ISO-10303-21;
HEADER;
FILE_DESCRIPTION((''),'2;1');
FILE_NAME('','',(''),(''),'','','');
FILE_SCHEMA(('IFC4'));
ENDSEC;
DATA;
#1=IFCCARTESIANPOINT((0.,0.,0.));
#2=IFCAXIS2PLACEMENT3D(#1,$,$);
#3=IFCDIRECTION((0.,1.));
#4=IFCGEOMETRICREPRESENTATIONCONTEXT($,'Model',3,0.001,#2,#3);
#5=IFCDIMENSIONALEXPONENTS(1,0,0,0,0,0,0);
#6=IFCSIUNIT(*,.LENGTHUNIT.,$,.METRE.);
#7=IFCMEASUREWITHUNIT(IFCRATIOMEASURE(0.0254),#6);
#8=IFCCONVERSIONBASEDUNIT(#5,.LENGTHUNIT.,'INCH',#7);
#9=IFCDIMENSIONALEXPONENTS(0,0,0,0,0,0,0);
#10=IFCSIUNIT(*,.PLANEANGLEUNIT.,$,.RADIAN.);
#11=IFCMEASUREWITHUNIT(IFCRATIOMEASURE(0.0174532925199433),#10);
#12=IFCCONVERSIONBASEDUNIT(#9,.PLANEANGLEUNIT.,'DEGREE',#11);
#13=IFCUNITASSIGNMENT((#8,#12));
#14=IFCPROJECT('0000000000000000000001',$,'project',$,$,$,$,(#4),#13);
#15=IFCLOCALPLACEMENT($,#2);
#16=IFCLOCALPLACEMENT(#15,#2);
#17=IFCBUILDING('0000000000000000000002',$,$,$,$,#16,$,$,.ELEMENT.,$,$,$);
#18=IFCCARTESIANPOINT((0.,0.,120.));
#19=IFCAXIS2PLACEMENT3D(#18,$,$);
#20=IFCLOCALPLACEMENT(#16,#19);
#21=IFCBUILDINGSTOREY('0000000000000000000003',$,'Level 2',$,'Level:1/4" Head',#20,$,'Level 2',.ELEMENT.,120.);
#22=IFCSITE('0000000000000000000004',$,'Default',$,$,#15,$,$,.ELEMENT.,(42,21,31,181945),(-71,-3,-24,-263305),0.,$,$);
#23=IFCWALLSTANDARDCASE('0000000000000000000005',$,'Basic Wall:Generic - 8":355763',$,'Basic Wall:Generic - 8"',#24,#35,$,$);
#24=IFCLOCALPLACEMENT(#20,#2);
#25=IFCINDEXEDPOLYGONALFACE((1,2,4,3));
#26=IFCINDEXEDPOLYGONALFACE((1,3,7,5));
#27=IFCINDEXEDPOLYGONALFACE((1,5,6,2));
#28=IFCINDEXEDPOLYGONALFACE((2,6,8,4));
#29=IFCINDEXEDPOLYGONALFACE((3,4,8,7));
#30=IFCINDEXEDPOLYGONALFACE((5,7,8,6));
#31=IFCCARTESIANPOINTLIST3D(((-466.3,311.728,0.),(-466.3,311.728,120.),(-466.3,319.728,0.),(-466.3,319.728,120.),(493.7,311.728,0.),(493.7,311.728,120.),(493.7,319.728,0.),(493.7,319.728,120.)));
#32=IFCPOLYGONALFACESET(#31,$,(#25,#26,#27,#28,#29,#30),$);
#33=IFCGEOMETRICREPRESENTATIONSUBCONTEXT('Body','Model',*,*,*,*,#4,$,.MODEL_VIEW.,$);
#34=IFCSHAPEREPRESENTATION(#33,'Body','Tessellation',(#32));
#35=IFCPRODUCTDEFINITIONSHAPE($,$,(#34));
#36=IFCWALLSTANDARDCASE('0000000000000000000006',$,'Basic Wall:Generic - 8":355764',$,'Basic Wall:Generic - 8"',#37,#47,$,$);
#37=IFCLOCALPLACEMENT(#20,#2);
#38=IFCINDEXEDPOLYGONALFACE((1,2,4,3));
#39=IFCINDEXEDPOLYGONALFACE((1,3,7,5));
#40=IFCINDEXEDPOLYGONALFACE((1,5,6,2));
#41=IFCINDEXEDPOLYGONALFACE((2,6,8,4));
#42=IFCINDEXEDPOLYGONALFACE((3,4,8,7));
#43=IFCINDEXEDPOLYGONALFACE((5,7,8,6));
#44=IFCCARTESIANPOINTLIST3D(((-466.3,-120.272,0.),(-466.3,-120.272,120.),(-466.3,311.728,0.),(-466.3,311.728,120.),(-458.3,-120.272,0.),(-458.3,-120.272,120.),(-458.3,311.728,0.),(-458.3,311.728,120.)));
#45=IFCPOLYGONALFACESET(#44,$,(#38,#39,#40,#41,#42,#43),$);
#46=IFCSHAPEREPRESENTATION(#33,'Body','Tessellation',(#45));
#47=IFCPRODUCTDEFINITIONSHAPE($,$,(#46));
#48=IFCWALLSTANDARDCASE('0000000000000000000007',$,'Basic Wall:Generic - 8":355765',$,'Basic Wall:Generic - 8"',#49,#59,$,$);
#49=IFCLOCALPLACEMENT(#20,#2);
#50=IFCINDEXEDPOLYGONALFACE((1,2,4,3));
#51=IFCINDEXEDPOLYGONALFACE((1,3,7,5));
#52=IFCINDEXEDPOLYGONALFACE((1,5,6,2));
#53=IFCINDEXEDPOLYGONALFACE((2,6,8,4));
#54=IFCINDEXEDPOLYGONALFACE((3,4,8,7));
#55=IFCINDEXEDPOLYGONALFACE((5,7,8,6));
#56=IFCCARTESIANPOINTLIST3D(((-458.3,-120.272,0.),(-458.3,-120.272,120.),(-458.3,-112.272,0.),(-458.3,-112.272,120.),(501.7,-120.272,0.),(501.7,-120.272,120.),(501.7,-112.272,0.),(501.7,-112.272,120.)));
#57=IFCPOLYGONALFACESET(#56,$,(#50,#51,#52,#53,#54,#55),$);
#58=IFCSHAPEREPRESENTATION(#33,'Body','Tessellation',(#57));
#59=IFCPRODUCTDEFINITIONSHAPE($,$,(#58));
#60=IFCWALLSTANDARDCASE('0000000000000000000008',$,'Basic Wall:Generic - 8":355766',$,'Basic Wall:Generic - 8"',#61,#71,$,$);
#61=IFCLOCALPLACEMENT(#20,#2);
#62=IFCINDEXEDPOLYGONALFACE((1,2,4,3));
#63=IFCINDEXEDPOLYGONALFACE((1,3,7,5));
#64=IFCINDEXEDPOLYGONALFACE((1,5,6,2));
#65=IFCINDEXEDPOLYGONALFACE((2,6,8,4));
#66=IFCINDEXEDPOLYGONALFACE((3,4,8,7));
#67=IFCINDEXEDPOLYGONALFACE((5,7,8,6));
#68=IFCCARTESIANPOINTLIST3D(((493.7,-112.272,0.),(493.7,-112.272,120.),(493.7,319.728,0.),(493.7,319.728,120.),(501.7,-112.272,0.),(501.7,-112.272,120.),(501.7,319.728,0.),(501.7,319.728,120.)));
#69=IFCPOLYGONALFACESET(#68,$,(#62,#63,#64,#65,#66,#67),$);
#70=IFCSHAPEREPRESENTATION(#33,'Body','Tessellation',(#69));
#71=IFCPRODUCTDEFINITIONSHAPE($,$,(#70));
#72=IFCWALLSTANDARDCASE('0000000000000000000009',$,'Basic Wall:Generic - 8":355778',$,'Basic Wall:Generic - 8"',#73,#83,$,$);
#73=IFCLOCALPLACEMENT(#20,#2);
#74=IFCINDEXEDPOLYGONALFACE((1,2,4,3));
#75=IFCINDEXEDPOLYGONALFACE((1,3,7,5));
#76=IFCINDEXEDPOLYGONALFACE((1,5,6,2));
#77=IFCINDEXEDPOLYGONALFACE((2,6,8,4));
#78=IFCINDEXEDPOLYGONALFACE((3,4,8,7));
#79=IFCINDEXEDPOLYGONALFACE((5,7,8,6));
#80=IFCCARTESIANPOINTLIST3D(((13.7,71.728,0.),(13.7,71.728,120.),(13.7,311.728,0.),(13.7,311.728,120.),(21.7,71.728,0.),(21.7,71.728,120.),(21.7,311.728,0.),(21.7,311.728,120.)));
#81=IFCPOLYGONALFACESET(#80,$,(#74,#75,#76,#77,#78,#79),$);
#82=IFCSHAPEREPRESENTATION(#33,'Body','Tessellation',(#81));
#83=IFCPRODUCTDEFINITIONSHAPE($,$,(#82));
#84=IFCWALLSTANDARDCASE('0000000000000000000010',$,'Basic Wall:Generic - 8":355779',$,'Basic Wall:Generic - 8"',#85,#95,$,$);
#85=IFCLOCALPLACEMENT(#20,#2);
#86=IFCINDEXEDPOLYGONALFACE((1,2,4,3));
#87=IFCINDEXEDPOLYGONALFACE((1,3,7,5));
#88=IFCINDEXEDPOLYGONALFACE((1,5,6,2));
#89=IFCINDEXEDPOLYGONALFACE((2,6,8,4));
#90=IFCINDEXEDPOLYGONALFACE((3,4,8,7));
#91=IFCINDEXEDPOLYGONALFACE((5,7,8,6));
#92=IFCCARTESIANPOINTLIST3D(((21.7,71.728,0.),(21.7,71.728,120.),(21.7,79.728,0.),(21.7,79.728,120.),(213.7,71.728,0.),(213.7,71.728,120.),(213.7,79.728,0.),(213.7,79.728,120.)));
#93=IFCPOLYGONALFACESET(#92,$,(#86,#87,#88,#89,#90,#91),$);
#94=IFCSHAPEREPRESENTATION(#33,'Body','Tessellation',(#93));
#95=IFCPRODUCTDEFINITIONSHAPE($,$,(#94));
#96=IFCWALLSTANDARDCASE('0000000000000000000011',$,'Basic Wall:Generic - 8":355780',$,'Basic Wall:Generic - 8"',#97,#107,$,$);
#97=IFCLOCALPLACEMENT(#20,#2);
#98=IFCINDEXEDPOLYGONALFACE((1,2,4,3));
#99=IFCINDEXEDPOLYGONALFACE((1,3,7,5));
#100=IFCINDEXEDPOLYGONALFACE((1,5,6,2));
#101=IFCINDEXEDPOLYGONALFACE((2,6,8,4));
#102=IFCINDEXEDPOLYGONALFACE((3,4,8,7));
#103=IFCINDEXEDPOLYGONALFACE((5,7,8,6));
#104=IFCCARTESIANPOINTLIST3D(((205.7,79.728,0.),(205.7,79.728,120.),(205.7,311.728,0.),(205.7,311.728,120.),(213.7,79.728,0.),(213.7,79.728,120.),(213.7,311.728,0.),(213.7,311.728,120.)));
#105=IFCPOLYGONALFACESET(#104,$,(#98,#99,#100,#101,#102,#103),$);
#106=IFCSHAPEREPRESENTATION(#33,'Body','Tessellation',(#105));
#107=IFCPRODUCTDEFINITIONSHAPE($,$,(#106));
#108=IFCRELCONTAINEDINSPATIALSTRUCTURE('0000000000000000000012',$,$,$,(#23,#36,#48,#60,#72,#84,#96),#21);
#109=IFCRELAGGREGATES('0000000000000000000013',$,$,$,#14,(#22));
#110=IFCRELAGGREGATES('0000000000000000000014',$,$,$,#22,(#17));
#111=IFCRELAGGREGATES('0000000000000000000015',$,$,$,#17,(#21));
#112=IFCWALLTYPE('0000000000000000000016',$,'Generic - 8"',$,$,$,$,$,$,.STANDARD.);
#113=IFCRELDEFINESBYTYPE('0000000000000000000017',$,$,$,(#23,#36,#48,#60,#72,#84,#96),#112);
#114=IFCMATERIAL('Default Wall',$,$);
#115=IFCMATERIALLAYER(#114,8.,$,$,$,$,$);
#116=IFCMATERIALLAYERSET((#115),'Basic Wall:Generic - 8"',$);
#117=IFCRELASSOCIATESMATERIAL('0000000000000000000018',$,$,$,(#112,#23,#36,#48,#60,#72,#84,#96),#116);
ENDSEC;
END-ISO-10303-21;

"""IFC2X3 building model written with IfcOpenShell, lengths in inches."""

from ifc_helpers import new_model, entity, si_unit, converted_unit, direction, frame, frame_2d, origin, place, context, subcontext, project, spatial, rectangle, extrude, clip, halfspace, material, layer, layer_set, layer_usage, type_object, element, save


model = new_model("IFC2X3")

# Units and contexts
model_context = context("Model", 3, precision=0.001, world=origin(), true_north=direction((0.0, 1.0)))
body_context = subcontext(model_context, "Body", "Model", "MODEL_VIEW")
ifc_project = project(units=[converted_unit("LENGTHUNIT", "INCH", entity("IfcRatioMeasure", 0.0254), si_unit("LENGTHUNIT", "METRE"), dimensions=[1, 0, 0, 0, 0, 0, 0]), converted_unit("PLANEANGLEUNIT", "DEGREE", entity("IfcRatioMeasure", 0.0174532925199433), si_unit("PLANEANGLEUNIT", "RADIAN"), dimensions=[0, 0, 0, 0, 0, 0, 0])], contexts=[model_context])

# Site, building, storey
site_placement = place(None, origin())
site = spatial("IfcSite", under=ifc_project, at=site_placement, Name="Default", CompositionType="ELEMENT", RefLatitude=(42, 21, 31, 181945), RefLongitude=(-71, -3, -24, -263305), RefElevation=0.0)
building_placement = place(site_placement, origin())
building = spatial("IfcBuilding", under=site, at=building_placement, CompositionType="ELEMENT")
storey_placement = place(building_placement, frame((0.0, 0.0, 120.0)))
storey = spatial("IfcBuildingStorey", under=building, at=storey_placement, Name="Level 2", ObjectType="Level:1/4\" Head", LongName="Level 2", CompositionType="ELEMENT", Elevation=120.0)

# Walls
ifc_material = material(Name="Default Wall")
ifc_layer = layer(ifc_material, 8.0)
ifc_layer_set = layer_set([ifc_layer], Name="Basic Wall:Generic - 8\"")
ifc_layer_usage_1 = layer_usage(ifc_layer_set, "AXIS2", "NEGATIVE", 4.0)
wall_type = type_object("IfcWallType", Name="Generic - 8\"", PredefinedType="STANDARD", material=ifc_layer_set)
wall_1_placement = place(storey_placement, frame((-466.3, 315.728, 0.0)))
element("IfcWallStandardCase", 1, at=wall_1_placement, inside=storey, type_object=wall_type, material=ifc_layer_usage_1, Name="Basic Wall:Generic - 8\":355763", ObjectType="Basic Wall:Generic - 8\"", context=body_context, shape_type="Clipping", body=[
    clip(extrude(rectangle(XDim=960.0, YDim=8.0, at=frame_2d((480.0, 0.0), x_axis=(-1.0, 0.0))), origin(), (0.0, 0.0, 1.0), 120.0), halfspace(frame((0.0, 0.0, -120.0)), True)),
])
ifc_layer_usage_2 = layer_usage(ifc_layer_set, "AXIS2", "NEGATIVE", 4.0)
wall_2_placement = place(storey_placement, frame((-462.3, -120.272, 0.0), z_axis=(0.0, 0.0, 1.0), x_axis=(0.0, 1.0, 0.0)))
element("IfcWallStandardCase", 2, at=wall_2_placement, inside=storey, type_object=wall_type, material=ifc_layer_usage_2, Name="Basic Wall:Generic - 8\":355764", ObjectType="Basic Wall:Generic - 8\"", context=body_context, shape_type="Clipping", body=[
    clip(extrude(rectangle(XDim=432.0, YDim=8.0, at=frame_2d((216.0, 0.0), x_axis=(-1.0, 0.0))), origin(), (0.0, 0.0, 1.0), 120.0), halfspace(frame((0.0, 0.0, -120.0)), True)),
])
ifc_layer_usage_3 = layer_usage(ifc_layer_set, "AXIS2", "NEGATIVE", 4.0)
wall_3_placement = place(storey_placement, frame((501.7, -116.272, 0.0), z_axis=(0.0, 0.0, 1.0), x_axis=(-1.0, 0.0, 0.0)))
element("IfcWallStandardCase", 3, at=wall_3_placement, inside=storey, type_object=wall_type, material=ifc_layer_usage_3, Name="Basic Wall:Generic - 8\":355765", ObjectType="Basic Wall:Generic - 8\"", context=body_context, shape_type="Clipping", body=[
    clip(extrude(rectangle(XDim=960.0, YDim=8.0, at=frame_2d((480.0, 0.0), x_axis=(-1.0, 0.0))), origin(), (0.0, 0.0, 1.0), 120.0), halfspace(frame((0.0, 0.0, -120.0)), True)),
])
ifc_layer_usage_4 = layer_usage(ifc_layer_set, "AXIS2", "NEGATIVE", 4.0)
wall_4_placement = place(storey_placement, frame((497.7, 319.728, 0.0), z_axis=(0.0, 0.0, 1.0), x_axis=(0.0, -1.0, 0.0)))
element("IfcWallStandardCase", 4, at=wall_4_placement, inside=storey, type_object=wall_type, material=ifc_layer_usage_4, Name="Basic Wall:Generic - 8\":355766", ObjectType="Basic Wall:Generic - 8\"", context=body_context, shape_type="Clipping", body=[
    clip(extrude(rectangle(XDim=432.0, YDim=8.0, at=frame_2d((216.0, 0.0), x_axis=(-1.0, 0.0))), origin(), (0.0, 0.0, 1.0), 120.0), halfspace(frame((0.0, 0.0, -120.0)), True)),
])
ifc_layer_usage_5 = layer_usage(ifc_layer_set, "AXIS2", "NEGATIVE", 4.0)
wall_5_placement = place(storey_placement, frame((17.7, 71.728, 0.0), z_axis=(0.0, 0.0, 1.0), x_axis=(0.0, 1.0, 0.0)))
element("IfcWallStandardCase", 5, at=wall_5_placement, inside=storey, type_object=wall_type, material=ifc_layer_usage_5, Name="Basic Wall:Generic - 8\":355778", ObjectType="Basic Wall:Generic - 8\"", context=body_context, shape_type="Clipping", body=[
    clip(extrude(rectangle(XDim=240.0, YDim=8.0, at=frame_2d((120.0, 0.0), x_axis=(-1.0, 0.0))), origin(), (0.0, 0.0, 1.0), 120.0), halfspace(frame((0.0, 0.0, -120.0)), True)),
])
ifc_layer_usage_6 = layer_usage(ifc_layer_set, "AXIS2", "NEGATIVE", 4.0)
wall_6_placement = place(storey_placement, frame((213.7, 75.728, 0.0), z_axis=(0.0, 0.0, 1.0), x_axis=(-1.0, 0.0, 0.0)))
element("IfcWallStandardCase", 6, at=wall_6_placement, inside=storey, type_object=wall_type, material=ifc_layer_usage_6, Name="Basic Wall:Generic - 8\":355779", ObjectType="Basic Wall:Generic - 8\"", context=body_context, shape_type="Clipping", body=[
    clip(extrude(rectangle(XDim=192.0, YDim=8.0, at=frame_2d((96.0, 0.0), x_axis=(-1.0, 0.0))), origin(), (0.0, 0.0, 1.0), 120.0), halfspace(frame((0.0, 0.0, -120.0)), True)),
])
ifc_layer_usage_7 = layer_usage(ifc_layer_set, "AXIS2", "NEGATIVE", 4.0)
wall_7_placement = place(storey_placement, frame((209.7, 311.728, 0.0), z_axis=(0.0, 0.0, 1.0), x_axis=(0.0, -1.0, 0.0)))
element("IfcWallStandardCase", 7, at=wall_7_placement, inside=storey, type_object=wall_type, material=ifc_layer_usage_7, Name="Basic Wall:Generic - 8\":355780", ObjectType="Basic Wall:Generic - 8\"", context=body_context, shape_type="Clipping", body=[
    clip(extrude(rectangle(XDim=232.0, YDim=8.0, at=frame_2d((116.0, 0.0), x_axis=(-1.0, 0.0))), origin(), (0.0, 0.0, 1.0), 120.0), halfspace(frame((0.0, 0.0, -120.0)), True)),
])

save(model, "model.ifc")
